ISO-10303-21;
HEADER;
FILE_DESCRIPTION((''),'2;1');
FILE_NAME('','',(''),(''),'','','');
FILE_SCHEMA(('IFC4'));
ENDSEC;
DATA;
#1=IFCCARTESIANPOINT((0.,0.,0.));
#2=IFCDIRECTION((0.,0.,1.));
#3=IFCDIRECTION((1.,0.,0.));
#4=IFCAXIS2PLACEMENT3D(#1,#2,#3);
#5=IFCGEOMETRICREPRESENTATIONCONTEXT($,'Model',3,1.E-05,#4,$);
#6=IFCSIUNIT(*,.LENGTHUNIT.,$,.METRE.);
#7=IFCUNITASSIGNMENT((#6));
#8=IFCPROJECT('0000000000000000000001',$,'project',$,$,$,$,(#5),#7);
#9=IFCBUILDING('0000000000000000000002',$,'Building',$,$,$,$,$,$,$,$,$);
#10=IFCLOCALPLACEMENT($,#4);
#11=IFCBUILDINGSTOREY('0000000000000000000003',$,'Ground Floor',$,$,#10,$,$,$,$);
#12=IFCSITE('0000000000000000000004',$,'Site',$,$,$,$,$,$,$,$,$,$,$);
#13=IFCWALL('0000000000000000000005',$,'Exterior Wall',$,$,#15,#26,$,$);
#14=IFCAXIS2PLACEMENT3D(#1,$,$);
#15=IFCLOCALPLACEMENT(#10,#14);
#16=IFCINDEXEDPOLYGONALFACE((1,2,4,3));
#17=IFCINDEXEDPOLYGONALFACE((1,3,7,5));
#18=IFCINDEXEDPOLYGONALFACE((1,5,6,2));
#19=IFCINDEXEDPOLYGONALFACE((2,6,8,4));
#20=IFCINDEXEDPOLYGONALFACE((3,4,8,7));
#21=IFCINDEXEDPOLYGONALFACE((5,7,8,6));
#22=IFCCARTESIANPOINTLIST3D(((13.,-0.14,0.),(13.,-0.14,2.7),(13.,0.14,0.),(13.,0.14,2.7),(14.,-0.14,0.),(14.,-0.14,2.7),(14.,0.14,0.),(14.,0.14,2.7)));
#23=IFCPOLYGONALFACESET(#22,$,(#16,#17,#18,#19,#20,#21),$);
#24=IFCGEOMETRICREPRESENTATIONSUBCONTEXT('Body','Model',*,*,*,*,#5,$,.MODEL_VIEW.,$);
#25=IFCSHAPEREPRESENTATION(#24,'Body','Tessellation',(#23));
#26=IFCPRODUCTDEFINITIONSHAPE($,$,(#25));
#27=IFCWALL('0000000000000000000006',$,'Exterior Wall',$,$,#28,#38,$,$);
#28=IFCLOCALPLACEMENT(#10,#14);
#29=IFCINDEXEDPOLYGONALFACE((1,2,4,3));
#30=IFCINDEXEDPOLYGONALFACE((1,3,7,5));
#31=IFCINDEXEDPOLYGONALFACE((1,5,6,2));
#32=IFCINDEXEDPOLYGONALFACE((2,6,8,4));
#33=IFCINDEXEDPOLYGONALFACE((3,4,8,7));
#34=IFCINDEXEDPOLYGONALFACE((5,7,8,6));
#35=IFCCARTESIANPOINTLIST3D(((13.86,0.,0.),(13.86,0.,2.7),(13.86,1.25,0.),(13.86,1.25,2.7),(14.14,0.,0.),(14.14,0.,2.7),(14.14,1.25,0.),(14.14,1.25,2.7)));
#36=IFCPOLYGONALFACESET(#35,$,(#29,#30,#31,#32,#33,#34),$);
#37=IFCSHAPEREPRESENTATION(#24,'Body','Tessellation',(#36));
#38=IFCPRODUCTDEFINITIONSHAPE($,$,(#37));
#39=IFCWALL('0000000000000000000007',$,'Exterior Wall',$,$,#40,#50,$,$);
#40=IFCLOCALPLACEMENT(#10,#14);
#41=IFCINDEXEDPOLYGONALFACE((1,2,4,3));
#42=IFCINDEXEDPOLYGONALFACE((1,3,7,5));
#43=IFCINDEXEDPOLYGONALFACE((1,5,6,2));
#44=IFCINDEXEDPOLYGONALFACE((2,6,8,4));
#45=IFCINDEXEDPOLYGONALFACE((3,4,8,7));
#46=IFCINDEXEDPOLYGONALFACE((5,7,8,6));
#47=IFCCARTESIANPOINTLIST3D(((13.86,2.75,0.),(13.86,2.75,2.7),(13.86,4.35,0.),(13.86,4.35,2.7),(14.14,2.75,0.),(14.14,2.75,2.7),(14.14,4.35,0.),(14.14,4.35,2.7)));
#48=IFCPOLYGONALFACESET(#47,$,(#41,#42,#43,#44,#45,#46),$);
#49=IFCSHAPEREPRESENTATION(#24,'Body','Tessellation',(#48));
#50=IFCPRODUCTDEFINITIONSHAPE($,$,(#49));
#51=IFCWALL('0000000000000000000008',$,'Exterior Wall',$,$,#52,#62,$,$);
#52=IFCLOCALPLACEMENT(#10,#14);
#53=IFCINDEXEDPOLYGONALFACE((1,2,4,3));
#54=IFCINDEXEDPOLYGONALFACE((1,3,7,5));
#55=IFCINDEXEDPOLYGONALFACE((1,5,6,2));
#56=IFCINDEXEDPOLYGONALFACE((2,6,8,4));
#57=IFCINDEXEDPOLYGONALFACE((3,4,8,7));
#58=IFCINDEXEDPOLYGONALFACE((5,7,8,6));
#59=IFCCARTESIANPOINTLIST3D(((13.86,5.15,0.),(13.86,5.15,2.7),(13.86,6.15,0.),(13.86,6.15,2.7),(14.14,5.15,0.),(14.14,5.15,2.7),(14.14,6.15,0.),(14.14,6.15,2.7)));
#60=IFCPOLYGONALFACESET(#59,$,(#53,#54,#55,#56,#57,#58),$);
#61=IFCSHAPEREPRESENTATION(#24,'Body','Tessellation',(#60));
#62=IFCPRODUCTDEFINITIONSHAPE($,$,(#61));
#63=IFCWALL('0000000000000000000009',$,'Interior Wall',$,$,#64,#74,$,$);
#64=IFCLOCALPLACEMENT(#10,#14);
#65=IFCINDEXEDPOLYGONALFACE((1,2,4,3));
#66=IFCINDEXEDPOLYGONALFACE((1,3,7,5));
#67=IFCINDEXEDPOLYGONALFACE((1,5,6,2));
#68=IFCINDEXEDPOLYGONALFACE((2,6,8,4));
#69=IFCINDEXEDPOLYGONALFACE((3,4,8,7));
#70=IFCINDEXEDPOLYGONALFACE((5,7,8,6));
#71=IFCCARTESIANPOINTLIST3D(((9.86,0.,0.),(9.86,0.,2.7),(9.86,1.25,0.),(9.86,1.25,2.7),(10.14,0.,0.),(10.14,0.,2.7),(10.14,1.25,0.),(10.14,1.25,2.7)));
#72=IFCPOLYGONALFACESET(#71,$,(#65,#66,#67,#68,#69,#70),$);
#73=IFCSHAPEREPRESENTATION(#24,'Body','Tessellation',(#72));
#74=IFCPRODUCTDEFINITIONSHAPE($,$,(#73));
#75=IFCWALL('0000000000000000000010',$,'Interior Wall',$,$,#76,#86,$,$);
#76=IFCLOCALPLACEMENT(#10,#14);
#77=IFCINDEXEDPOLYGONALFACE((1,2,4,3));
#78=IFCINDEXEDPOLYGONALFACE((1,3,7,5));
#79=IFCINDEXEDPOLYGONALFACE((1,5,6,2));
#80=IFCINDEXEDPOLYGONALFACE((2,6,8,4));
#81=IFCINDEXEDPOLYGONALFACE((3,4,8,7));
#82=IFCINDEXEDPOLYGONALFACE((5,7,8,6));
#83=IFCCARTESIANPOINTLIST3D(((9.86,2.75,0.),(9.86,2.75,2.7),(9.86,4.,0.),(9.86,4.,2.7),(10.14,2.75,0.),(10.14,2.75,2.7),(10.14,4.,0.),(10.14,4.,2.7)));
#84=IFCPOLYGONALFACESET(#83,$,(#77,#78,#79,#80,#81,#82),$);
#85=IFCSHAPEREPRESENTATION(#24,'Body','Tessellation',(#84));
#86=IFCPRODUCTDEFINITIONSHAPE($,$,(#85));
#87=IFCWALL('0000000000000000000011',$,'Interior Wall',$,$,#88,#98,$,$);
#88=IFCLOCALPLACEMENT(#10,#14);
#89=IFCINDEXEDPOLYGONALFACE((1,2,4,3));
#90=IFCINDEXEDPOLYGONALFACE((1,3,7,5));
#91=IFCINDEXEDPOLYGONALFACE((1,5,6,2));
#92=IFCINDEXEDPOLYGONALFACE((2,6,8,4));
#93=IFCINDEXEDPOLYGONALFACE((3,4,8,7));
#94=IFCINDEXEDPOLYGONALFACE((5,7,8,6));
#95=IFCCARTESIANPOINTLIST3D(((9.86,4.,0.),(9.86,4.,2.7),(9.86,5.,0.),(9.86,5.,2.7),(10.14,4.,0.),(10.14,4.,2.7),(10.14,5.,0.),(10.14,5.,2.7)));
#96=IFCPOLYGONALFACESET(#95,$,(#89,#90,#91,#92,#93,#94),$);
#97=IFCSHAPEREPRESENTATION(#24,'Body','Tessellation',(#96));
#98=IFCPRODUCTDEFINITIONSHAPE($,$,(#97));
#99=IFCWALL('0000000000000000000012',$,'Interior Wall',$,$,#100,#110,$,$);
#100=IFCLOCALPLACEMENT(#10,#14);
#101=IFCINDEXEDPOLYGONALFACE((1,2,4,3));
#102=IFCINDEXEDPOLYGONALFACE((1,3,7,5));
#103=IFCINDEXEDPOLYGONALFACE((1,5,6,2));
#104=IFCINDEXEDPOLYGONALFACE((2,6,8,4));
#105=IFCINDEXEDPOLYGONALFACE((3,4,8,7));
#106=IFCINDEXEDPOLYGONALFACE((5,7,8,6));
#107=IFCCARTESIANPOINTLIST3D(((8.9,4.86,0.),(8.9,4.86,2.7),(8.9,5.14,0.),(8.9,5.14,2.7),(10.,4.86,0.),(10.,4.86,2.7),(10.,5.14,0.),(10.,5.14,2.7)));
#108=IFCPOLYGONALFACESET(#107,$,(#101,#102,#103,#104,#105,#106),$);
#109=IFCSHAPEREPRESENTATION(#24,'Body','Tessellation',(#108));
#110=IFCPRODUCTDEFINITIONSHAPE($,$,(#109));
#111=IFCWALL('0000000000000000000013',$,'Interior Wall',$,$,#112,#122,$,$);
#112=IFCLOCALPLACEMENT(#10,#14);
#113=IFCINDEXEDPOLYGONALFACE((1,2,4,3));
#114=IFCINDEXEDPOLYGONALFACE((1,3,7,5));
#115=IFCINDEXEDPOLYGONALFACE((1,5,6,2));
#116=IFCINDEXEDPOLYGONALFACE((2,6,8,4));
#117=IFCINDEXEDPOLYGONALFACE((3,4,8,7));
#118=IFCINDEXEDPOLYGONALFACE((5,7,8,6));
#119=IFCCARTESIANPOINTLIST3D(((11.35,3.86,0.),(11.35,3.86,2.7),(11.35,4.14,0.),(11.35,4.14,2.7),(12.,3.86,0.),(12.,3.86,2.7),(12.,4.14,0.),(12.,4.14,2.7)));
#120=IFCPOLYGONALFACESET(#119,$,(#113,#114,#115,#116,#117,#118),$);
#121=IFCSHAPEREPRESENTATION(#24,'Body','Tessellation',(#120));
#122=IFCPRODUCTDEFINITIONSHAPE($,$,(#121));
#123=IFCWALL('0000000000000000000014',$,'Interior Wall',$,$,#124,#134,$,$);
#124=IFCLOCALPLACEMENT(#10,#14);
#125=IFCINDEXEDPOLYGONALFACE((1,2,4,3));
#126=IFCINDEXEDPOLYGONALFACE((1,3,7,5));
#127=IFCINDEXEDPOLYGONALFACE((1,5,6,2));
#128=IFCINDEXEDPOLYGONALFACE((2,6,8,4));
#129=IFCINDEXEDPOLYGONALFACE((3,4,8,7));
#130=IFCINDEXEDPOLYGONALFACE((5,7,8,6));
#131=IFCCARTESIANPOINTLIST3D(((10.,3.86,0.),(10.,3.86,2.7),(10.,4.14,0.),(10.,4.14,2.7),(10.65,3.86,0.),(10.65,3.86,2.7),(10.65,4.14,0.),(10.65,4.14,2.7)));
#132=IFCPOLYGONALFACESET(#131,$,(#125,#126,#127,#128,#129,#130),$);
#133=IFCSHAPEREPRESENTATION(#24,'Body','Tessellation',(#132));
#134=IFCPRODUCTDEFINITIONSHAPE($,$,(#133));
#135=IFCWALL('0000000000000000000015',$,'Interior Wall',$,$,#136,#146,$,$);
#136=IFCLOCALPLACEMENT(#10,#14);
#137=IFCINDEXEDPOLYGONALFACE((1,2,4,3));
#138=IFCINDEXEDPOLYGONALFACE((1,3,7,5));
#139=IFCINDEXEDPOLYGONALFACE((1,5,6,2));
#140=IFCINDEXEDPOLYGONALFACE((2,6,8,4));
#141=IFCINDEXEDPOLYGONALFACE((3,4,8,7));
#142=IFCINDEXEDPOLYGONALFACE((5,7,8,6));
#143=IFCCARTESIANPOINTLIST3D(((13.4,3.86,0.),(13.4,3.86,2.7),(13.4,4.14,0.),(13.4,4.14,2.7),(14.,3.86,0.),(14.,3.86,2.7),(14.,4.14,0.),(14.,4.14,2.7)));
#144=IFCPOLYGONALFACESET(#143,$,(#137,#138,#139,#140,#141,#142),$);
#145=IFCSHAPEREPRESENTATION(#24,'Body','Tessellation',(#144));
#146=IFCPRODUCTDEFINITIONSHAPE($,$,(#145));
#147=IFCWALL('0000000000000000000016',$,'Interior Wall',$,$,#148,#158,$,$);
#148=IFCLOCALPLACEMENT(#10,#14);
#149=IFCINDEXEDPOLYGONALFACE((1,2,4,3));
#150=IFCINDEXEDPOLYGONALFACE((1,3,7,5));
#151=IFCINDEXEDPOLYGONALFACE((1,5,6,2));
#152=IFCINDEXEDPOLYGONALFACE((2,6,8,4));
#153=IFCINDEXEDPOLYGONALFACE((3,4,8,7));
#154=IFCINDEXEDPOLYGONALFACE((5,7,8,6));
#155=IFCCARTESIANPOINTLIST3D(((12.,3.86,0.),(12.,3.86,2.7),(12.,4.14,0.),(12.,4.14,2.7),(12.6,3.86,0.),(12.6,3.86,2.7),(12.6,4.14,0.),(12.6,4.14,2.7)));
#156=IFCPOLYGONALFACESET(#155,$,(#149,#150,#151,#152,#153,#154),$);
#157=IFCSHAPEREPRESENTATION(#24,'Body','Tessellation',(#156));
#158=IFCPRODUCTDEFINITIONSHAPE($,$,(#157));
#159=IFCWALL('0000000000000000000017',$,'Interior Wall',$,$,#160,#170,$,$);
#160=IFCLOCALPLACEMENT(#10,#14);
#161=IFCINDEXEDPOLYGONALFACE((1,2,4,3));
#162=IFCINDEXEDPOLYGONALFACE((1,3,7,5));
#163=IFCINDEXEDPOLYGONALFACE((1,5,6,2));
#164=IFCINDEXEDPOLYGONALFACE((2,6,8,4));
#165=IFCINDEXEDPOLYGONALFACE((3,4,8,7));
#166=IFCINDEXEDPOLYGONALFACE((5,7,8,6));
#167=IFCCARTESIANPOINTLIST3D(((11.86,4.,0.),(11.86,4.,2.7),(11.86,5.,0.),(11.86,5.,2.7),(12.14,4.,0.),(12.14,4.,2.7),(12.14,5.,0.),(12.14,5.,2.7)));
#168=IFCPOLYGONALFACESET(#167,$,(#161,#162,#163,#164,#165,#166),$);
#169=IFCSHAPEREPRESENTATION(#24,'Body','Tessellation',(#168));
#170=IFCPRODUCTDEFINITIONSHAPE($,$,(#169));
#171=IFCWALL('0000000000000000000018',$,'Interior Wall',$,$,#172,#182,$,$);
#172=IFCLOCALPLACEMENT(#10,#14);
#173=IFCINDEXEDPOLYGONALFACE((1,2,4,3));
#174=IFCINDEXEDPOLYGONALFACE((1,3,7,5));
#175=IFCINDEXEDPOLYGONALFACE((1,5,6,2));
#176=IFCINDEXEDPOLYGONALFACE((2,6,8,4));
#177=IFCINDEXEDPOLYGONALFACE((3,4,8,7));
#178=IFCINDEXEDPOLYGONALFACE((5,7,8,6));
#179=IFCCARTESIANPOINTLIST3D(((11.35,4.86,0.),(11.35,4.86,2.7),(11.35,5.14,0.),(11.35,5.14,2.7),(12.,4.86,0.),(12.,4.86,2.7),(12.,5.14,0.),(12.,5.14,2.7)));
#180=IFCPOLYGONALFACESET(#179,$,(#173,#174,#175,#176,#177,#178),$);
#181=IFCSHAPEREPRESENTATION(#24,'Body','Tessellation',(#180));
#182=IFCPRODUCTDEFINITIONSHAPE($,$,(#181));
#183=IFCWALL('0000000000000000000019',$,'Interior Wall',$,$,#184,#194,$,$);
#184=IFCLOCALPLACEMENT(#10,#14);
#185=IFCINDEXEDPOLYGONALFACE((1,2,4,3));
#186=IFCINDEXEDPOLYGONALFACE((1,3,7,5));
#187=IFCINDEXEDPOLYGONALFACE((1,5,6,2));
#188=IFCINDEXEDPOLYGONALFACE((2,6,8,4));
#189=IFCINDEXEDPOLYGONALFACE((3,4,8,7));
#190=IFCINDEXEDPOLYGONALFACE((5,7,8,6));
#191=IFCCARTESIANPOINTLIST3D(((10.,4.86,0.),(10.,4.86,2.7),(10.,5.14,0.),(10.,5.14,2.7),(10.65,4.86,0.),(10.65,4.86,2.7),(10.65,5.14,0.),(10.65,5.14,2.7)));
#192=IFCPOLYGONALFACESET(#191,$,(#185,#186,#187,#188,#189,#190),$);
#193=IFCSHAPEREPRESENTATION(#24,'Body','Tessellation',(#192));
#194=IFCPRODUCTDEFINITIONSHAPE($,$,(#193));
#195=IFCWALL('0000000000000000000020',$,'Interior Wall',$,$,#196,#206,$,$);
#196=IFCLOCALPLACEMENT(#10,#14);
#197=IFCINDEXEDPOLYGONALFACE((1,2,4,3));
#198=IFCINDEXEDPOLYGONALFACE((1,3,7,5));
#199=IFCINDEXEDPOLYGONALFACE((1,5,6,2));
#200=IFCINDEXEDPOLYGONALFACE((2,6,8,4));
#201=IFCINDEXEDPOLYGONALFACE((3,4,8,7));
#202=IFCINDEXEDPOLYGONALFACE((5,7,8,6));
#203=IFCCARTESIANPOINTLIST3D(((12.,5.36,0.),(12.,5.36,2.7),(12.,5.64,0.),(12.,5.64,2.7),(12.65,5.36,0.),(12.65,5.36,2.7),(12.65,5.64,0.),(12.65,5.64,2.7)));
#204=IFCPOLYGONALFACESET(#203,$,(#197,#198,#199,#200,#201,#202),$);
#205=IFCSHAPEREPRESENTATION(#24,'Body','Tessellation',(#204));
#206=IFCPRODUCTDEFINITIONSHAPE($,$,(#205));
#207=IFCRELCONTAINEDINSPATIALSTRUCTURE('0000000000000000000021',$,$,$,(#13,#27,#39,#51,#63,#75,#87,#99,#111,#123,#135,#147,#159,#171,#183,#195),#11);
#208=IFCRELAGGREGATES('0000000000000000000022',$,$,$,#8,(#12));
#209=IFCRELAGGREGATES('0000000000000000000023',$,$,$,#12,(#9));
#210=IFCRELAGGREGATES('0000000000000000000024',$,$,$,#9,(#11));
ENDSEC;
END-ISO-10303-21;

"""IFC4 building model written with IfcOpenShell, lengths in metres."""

from ifc_helpers import new_model, si_unit, frame, origin_with_axes, place, context, subcontext, project, spatial, indexed_curve, outline, extrude, element, save


model = new_model("IFC4")

# Units and contexts
model_context = context("Model", 3, precision=1e-05, world=origin_with_axes())
body_context = subcontext(model_context, "Body", "Model", "MODEL_VIEW")
ifc_project = project(units=[si_unit("LENGTHUNIT", "METRE")], contexts=[model_context])

# Site, building, storey
site = spatial("IfcSite", under=ifc_project, Name="Site")
building = spatial("IfcBuilding", under=site, Name="Building")
storey_placement = place(None, origin_with_axes())
storey = spatial("IfcBuildingStorey", under=building, at=storey_placement, Name="Ground Floor")

# Walls
wall_1_placement = place(storey_placement, frame((13.0, 0.0, 0.0), z_axis=(0.0, 0.0, 1.0), x_axis=(1.0, 0.0, 0.0)))
element("IfcWall", 1, at=wall_1_placement, inside=storey, Name="Exterior Wall", context=body_context, shape_type="SweptSolid", body=[
    extrude(outline(indexed_curve([(0.0, 0.0), (0.0, 0.28), (1.0, 0.28), (1.0, 0.0), (0.0, 0.0)], self_intersect=False)), frame((0.0, -0.14, 0.0), z_axis=(0.0, 0.0, 1.0), x_axis=(1.0, 0.0, 0.0)), (0.0, 0.0, 1.0), 2.7),
])
wall_2_placement = place(storey_placement, frame((14.0, 0.0, 0.0), z_axis=(0.0, 0.0, 1.0), x_axis=(0.0, 1.0, 0.0)))
element("IfcWall", 2, at=wall_2_placement, inside=storey, Name="Exterior Wall", context=body_context, shape_type="SweptSolid", body=[
    extrude(outline(indexed_curve([(0.0, 0.0), (0.0, 0.28), (1.25, 0.28), (1.25, 0.0), (0.0, 0.0)], self_intersect=False)), frame((0.0, -0.14, 0.0), z_axis=(0.0, 0.0, 1.0), x_axis=(1.0, 0.0, 0.0)), (0.0, 0.0, 1.0), 2.7),
])
wall_3_placement = place(storey_placement, frame((14.0, 2.75, 0.0), z_axis=(0.0, 0.0, 1.0), x_axis=(0.0, 1.0, 0.0)))
element("IfcWall", 3, at=wall_3_placement, inside=storey, Name="Exterior Wall", context=body_context, shape_type="SweptSolid", body=[
    extrude(outline(indexed_curve([(0.0, 0.0), (0.0, 0.28), (1.6, 0.28), (1.6, 0.0), (0.0, 0.0)], self_intersect=False)), frame((0.0, -0.14, 0.0), z_axis=(0.0, 0.0, 1.0), x_axis=(1.0, 0.0, 0.0)), (0.0, 0.0, 1.0), 2.7),
])
wall_4_placement = place(storey_placement, frame((14.0, 5.15, 0.0), z_axis=(0.0, 0.0, 1.0), x_axis=(0.0, 1.0, 0.0)))
element("IfcWall", 4, at=wall_4_placement, inside=storey, Name="Exterior Wall", context=body_context, shape_type="SweptSolid", body=[
    extrude(outline(indexed_curve([(0.0, 0.0), (0.0, 0.28), (1.0, 0.28), (1.0, 0.0), (0.0, 0.0)], self_intersect=False)), frame((0.0, -0.14, 0.0), z_axis=(0.0, 0.0, 1.0), x_axis=(1.0, 0.0, 0.0)), (0.0, 0.0, 1.0), 2.7),
])
for number, where, z_axis, x_axis, name in (
    (5, (10.0, 0.0, 0.0), (0.0, 0.0, 1.0), (0.0, 1.0, 0.0), "Interior Wall"),
    (6, (10.0, 2.75, 0.0), (0.0, 0.0, 1.0), (0.0, 1.0, 0.0), "Interior Wall"),
):
    element("IfcWall", number, at=place(storey_placement, frame(where, z_axis=z_axis, x_axis=x_axis)), inside=storey, Name=name, context=body_context, shape_type="SweptSolid", body=[
        extrude(outline(indexed_curve([(0.0, 0.0), (0.0, 0.28), (1.25, 0.28), (1.25, 0.0), (0.0, 0.0)], self_intersect=False)), frame((0.0, -0.14, 0.0), z_axis=(0.0, 0.0, 1.0), x_axis=(1.0, 0.0, 0.0)), (0.0, 0.0, 1.0), 2.7),
    ])
wall_5_placement = place(storey_placement, frame((10.0, 4.0, 0.0), z_axis=(0.0, 0.0, 1.0), x_axis=(0.0, 1.0, 0.0)))
element("IfcWall", 7, at=wall_5_placement, inside=storey, Name="Interior Wall", context=body_context, shape_type="SweptSolid", body=[
    extrude(outline(indexed_curve([(0.0, 0.0), (0.0, 0.28), (1.0, 0.28), (1.0, 0.0), (0.0, 0.0)], self_intersect=False)), frame((0.0, -0.14, 0.0), z_axis=(0.0, 0.0, 1.0), x_axis=(1.0, 0.0, 0.0)), (0.0, 0.0, 1.0), 2.7),
])
wall_6_placement = place(storey_placement, frame((10.0, 5.0, 0.0), z_axis=(0.0, 0.0, 1.0), x_axis=(-1.0, 0.0, 0.0)))
element("IfcWall", 8, at=wall_6_placement, inside=storey, Name="Interior Wall", context=body_context, shape_type="SweptSolid", body=[
    extrude(outline(indexed_curve([(0.0, 0.0), (0.0, 0.28), (1.1, 0.28), (1.1, 0.0), (0.0, 0.0)], self_intersect=False)), frame((0.0, -0.14, 0.0), z_axis=(0.0, 0.0, 1.0), x_axis=(1.0, 0.0, 0.0)), (0.0, 0.0, 1.0), 2.7),
])
for number, where, z_axis, x_axis, name in (
    (9, (12.0, 4.0, 0.0), (0.0, 0.0, 1.0), (-1.0, 0.0, 0.0), "Interior Wall"),
    (10, (10.65, 4.0, 0.0), (0.0, 0.0, 1.0), (-1.0, 0.0, 0.0), "Interior Wall"),
):
    element("IfcWall", number, at=place(storey_placement, frame(where, z_axis=z_axis, x_axis=x_axis)), inside=storey, Name=name, context=body_context, shape_type="SweptSolid", body=[
        extrude(outline(indexed_curve([(0.0, 0.0), (0.0, 0.28), (0.65, 0.28), (0.65, 0.0), (0.0, 0.0)], self_intersect=False)), frame((0.0, -0.14, 0.0), z_axis=(0.0, 0.0, 1.0), x_axis=(1.0, 0.0, 0.0)), (0.0, 0.0, 1.0), 2.7),
    ])
for number, where, z_axis, x_axis, name in (
    (11, (14.0, 4.0, 0.0), (0.0, 0.0, 1.0), (-1.0, 0.0, 0.0), "Interior Wall"),
    (12, (12.6, 4.0, 0.0), (0.0, 0.0, 1.0), (-1.0, 0.0, 0.0), "Interior Wall"),
):
    element("IfcWall", number, at=place(storey_placement, frame(where, z_axis=z_axis, x_axis=x_axis)), inside=storey, Name=name, context=body_context, shape_type="SweptSolid", body=[
        extrude(outline(indexed_curve([(0.0, 0.0), (0.0, 0.28), (0.6, 0.28), (0.6, 0.0), (0.0, 0.0)], self_intersect=False)), frame((0.0, -0.14, 0.0), z_axis=(0.0, 0.0, 1.0), x_axis=(1.0, 0.0, 0.0)), (0.0, 0.0, 1.0), 2.7),
    ])
wall_7_placement = place(storey_placement, frame((12.0, 4.0, 0.0), z_axis=(0.0, 0.0, 1.0), x_axis=(0.0, 1.0, 0.0)))
element("IfcWall", 13, at=wall_7_placement, inside=storey, Name="Interior Wall", context=body_context, shape_type="SweptSolid", body=[
    extrude(outline(indexed_curve([(0.0, 0.0), (0.0, 0.28), (1.0, 0.28), (1.0, 0.0), (0.0, 0.0)], self_intersect=False)), frame((0.0, -0.14, 0.0), z_axis=(0.0, 0.0, 1.0), x_axis=(1.0, 0.0, 0.0)), (0.0, 0.0, 1.0), 2.7),
])
for number, where, z_axis, x_axis, name in (
    (14, (12.0, 5.0, 0.0), (0.0, 0.0, 1.0), (-1.0, 0.0, 0.0), "Interior Wall"),
    (15, (10.65, 5.0, 0.0), (0.0, 0.0, 1.0), (-1.0, 0.0, 0.0), "Interior Wall"),
    (16, (12.65, 5.5, 0.0), (0.0, 0.0, 1.0), (-1.0, 0.0, 0.0), "Interior Wall"),
):
    element("IfcWall", number, at=place(storey_placement, frame(where, z_axis=z_axis, x_axis=x_axis)), inside=storey, Name=name, context=body_context, shape_type="SweptSolid", body=[
        extrude(outline(indexed_curve([(0.0, 0.0), (0.0, 0.28), (0.65, 0.28), (0.65, 0.0), (0.0, 0.0)], self_intersect=False)), frame((0.0, -0.14, 0.0), z_axis=(0.0, 0.0, 1.0), x_axis=(1.0, 0.0, 0.0)), (0.0, 0.0, 1.0), 2.7),
    ])

save(model, "model.ifc")
